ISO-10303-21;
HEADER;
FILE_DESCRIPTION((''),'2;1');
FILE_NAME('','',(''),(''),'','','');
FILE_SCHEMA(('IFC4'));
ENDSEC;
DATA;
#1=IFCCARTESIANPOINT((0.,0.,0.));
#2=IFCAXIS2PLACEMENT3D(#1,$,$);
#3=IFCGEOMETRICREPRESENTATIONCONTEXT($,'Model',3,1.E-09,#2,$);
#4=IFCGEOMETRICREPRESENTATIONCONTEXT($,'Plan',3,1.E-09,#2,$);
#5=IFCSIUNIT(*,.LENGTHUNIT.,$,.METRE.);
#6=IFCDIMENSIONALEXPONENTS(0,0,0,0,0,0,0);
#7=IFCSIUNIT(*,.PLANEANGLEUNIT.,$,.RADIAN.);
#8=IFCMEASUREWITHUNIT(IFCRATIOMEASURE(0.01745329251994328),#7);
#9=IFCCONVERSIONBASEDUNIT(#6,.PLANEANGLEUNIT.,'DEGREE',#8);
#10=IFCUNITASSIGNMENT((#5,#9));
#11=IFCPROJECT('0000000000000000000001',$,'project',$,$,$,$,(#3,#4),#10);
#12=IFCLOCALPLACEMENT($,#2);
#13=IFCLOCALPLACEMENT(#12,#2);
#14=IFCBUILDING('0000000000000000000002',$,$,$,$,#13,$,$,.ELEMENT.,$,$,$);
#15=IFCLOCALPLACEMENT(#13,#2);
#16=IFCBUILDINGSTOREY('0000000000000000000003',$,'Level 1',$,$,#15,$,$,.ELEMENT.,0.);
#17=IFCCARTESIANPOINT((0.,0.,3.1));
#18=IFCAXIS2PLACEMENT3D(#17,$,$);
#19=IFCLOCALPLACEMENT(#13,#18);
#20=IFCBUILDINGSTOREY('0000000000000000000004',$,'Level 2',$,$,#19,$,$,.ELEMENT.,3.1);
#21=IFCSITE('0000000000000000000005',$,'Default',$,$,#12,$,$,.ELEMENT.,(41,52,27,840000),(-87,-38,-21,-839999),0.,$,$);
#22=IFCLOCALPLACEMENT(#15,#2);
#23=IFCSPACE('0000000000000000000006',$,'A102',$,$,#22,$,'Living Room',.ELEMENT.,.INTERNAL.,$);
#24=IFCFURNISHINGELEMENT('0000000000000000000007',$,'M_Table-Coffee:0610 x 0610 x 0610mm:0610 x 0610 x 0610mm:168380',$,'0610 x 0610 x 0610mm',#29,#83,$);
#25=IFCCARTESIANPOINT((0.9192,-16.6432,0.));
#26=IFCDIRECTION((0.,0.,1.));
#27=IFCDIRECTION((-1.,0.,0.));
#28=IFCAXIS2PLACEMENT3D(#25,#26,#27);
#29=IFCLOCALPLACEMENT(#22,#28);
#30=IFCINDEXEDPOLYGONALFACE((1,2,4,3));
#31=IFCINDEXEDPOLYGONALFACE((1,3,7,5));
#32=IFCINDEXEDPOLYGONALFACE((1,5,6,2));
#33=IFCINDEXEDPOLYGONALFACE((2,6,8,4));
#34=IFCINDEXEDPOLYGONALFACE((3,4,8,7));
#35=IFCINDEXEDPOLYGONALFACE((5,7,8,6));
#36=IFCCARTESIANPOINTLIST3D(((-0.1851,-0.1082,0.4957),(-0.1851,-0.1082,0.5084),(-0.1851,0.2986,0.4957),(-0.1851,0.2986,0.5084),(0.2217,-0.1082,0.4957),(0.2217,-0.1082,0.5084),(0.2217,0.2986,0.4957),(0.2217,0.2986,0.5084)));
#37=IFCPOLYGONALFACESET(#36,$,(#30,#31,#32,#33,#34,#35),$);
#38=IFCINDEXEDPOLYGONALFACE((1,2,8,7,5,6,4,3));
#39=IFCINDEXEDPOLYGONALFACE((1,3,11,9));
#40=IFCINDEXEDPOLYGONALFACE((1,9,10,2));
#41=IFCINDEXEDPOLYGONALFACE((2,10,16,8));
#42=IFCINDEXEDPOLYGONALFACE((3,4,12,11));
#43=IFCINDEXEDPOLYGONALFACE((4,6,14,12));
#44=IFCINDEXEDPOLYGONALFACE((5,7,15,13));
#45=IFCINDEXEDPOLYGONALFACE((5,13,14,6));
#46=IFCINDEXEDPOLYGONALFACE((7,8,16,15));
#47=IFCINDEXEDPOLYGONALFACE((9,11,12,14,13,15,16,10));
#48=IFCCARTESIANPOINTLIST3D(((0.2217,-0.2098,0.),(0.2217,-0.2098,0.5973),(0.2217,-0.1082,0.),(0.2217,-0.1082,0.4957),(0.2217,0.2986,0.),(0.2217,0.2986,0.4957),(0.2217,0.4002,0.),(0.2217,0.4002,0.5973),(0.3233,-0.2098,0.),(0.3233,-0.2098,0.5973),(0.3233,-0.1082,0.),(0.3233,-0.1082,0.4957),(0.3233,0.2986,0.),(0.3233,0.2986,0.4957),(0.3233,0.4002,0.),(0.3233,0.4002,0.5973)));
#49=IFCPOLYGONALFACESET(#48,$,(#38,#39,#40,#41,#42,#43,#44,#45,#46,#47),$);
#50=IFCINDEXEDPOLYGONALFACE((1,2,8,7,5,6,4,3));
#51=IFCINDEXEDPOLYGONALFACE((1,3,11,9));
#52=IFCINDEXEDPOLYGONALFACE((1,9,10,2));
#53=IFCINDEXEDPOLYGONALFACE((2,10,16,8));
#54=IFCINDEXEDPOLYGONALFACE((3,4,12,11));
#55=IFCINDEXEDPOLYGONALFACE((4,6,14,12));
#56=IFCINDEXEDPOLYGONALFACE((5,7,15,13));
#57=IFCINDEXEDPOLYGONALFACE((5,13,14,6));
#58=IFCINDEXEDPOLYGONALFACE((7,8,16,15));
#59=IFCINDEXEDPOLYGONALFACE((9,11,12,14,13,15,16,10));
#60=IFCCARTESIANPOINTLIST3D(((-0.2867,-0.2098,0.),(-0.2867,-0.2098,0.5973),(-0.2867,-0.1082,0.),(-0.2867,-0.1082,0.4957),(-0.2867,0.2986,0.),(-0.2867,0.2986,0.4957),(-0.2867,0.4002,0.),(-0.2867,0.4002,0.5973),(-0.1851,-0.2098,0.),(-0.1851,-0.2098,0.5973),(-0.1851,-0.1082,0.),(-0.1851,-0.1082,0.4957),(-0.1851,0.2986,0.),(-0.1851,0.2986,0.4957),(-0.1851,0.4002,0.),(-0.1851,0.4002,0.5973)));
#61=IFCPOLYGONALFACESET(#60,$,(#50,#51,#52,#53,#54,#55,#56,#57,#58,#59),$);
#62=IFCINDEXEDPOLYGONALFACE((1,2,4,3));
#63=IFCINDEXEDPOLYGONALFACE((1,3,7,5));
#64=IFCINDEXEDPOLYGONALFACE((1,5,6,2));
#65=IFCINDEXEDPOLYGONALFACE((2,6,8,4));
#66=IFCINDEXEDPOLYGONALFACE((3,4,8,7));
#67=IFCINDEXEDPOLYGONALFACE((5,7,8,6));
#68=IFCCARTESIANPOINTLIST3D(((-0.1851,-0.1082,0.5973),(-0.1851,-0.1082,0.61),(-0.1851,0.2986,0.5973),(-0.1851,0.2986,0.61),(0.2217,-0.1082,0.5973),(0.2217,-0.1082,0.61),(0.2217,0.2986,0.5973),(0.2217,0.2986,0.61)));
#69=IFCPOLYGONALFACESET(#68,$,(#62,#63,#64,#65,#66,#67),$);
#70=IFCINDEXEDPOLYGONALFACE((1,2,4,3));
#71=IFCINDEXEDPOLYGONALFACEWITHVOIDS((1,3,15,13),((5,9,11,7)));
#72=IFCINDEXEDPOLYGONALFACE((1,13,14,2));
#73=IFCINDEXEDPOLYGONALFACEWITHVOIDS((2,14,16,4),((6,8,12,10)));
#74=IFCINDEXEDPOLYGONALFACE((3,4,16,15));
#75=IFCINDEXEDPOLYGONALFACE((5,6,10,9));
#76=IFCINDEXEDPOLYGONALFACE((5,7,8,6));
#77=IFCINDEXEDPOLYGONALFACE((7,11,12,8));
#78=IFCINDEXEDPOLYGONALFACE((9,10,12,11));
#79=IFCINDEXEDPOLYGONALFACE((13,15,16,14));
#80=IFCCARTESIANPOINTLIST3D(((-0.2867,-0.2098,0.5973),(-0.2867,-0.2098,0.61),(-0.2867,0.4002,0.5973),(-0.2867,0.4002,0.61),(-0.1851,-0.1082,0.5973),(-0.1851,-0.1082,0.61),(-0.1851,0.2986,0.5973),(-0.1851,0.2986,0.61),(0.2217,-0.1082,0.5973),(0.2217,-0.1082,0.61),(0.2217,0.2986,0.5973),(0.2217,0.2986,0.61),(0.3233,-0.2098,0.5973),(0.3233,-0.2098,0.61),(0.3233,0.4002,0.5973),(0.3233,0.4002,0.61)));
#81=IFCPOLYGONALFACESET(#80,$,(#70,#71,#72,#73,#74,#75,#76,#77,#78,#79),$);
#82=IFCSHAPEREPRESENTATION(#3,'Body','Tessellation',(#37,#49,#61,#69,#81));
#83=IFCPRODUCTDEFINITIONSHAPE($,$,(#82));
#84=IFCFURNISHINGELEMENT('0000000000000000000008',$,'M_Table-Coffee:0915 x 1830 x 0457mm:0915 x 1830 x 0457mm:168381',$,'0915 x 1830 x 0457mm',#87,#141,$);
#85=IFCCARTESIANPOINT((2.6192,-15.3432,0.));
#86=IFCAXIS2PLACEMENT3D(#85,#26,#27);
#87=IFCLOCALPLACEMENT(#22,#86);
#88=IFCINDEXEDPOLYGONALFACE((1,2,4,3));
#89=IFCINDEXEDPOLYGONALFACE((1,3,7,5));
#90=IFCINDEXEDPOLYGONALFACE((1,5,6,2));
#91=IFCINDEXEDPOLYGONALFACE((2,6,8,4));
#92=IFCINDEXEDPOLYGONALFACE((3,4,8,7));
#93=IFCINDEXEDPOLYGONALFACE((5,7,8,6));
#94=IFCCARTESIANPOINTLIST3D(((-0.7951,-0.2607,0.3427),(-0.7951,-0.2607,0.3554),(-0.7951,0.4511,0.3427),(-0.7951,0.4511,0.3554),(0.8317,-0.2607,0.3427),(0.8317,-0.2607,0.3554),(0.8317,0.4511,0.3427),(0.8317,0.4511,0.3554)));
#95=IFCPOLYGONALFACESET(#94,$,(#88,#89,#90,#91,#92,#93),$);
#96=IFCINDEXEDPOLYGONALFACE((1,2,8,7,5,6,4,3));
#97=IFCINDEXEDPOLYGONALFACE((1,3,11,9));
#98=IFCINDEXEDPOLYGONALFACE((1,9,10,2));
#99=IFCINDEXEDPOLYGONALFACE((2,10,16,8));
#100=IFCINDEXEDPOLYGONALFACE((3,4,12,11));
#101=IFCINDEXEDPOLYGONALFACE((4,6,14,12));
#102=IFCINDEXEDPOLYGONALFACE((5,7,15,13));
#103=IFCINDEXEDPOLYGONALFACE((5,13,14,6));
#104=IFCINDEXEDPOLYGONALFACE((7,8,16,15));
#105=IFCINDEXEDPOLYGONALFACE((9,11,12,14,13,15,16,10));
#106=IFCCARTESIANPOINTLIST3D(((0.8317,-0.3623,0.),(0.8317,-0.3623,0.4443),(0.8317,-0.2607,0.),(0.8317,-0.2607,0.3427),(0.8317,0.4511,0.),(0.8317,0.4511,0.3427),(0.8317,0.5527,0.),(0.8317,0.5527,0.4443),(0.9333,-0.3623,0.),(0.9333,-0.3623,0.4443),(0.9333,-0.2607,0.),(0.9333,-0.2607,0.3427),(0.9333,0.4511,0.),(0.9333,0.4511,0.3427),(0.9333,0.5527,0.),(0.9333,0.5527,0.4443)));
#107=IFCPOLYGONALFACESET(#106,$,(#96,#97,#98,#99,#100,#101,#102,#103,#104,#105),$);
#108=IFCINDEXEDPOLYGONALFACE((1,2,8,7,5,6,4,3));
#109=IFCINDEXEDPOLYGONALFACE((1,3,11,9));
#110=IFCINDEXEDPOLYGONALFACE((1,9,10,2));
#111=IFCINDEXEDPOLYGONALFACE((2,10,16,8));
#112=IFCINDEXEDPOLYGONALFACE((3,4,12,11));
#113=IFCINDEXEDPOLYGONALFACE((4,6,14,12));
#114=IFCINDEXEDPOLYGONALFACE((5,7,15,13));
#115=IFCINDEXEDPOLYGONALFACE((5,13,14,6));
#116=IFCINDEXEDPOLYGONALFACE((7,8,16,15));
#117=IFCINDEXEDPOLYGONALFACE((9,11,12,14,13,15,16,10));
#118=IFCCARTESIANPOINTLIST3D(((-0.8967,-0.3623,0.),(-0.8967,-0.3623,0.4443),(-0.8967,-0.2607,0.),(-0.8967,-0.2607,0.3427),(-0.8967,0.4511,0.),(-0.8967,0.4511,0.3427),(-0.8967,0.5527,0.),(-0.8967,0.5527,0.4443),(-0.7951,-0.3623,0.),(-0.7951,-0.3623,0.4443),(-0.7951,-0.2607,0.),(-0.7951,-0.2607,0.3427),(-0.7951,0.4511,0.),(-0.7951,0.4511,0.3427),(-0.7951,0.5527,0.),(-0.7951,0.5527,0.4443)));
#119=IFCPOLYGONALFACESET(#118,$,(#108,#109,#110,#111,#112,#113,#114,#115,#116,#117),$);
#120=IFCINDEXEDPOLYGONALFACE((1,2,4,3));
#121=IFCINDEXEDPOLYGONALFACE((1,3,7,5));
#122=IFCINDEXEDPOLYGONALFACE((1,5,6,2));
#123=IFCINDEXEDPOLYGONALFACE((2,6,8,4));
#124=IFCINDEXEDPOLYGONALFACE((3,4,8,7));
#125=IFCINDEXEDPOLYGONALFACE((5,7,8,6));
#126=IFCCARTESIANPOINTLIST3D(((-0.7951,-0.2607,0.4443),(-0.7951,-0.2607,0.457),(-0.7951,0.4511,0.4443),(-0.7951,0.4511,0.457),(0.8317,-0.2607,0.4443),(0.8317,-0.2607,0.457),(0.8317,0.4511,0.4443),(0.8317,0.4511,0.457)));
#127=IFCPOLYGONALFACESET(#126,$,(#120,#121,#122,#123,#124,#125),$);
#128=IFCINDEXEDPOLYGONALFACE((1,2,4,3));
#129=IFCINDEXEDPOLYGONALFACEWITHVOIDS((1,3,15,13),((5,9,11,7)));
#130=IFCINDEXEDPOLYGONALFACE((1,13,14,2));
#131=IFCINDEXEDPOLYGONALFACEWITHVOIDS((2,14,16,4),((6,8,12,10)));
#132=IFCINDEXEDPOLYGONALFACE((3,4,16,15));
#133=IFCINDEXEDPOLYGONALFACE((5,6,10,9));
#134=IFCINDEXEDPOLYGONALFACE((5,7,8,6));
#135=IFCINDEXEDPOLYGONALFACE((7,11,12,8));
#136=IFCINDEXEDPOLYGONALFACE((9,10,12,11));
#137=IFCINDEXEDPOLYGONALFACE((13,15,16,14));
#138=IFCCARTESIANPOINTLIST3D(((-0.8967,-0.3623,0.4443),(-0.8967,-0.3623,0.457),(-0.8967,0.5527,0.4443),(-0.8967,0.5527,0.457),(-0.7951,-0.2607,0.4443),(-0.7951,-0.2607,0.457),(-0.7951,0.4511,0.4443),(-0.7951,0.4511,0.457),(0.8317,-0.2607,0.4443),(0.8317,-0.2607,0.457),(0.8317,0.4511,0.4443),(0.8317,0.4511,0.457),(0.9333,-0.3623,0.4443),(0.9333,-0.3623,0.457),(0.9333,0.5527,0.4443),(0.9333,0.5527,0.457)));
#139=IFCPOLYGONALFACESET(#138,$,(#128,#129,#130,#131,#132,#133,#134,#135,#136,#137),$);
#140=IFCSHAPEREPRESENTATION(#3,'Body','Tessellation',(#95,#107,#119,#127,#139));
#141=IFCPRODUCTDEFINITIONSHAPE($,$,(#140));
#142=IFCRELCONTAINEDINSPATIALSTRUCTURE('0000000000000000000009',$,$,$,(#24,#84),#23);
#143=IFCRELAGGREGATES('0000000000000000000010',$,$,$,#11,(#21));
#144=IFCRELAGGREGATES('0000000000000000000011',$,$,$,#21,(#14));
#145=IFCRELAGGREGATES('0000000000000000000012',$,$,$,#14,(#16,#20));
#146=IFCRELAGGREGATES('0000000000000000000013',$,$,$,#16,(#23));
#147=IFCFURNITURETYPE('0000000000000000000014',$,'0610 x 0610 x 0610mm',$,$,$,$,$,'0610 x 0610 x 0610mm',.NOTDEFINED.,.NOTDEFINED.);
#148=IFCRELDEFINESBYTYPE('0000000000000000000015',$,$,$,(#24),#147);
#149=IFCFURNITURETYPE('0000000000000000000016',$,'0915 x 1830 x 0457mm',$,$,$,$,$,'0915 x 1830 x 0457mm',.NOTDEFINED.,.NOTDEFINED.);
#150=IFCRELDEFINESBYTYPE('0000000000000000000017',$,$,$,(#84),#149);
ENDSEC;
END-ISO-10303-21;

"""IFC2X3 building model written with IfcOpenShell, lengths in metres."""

from ifc_helpers import new_model, entity, si_unit, converted_unit, frame, origin, origin_2d_with_axis, place, context, project, spatial, polyline, rectangle, outline, extrude, source, transform, mapped, type_object, type_shapes, element, save


model = new_model("IFC2X3")

# Units and contexts
model_context = context("Model", 3, precision=1e-09, world=origin())
plan_context = context("Plan", 3, precision=1e-09, world=origin())
ifc_project = project(units=[si_unit("LENGTHUNIT", "METRE"), converted_unit("PLANEANGLEUNIT", "DEGREE", entity("IfcRatioMeasure", 0.01745329251994328), si_unit("PLANEANGLEUNIT", "RADIAN"), dimensions=[0, 0, 0, 0, 0, 0, 0])], contexts=[model_context, plan_context])

# Site, building, storey
site_placement = place(None, origin())
site = spatial("IfcSite", under=ifc_project, at=site_placement, Name="Default", CompositionType="ELEMENT", RefLatitude=(41, 52, 27, 840000), RefLongitude=(-87, -38, -21, -839999), RefElevation=0.0)
building_placement = place(site_placement, origin())
building = spatial("IfcBuilding", under=site, at=building_placement, CompositionType="ELEMENT")
storey_1_placement = place(building_placement, origin())
storey_1 = spatial("IfcBuildingStorey", under=building, at=storey_1_placement, Name="Level 1", CompositionType="ELEMENT", Elevation=0.0)

# Shared definitions
storey_2_placement = place(building_placement, frame((0.0, 0.0, 3.1)))
storey_2 = spatial("IfcBuildingStorey", under=building, at=storey_2_placement, Name="Level 2", CompositionType="ELEMENT", Elevation=3.1)

# Shared definitions
space_1_placement = place(storey_1_placement, origin())
space_1 = spatial("IfcSpace", under=storey_1, at=space_1_placement, Name="A102", LongName="Living Room", CompositionType="ELEMENT", InteriorOrExteriorSpace="INTERNAL")

# Furnishing elements
furniture_type_1 = type_object("IfcFurnitureType", Name="0610 x 0610 x 0610mm", ElementType="0610 x 0610 x 0610mm", AssemblyPlace="NOTDEFINED")
shared_shape_1 = source(origin(), model_context, "Body", "SweptSolid", [
    extrude(rectangle(XDim=0.4068, YDim=0.4068, at=origin_2d_with_axis()), frame((0.0183, 0.0952, 0.4957), z_axis=(0.0, 0.0, 1.0), x_axis=(-1.0, 0.0, 0.0)), (0.0, 0.0, 1.0), 0.0127),
    extrude(outline(polyline([(-0.2732, -0.305), (0.324, -0.305), (0.324, 0.305), (-0.2732, 0.305), (-0.2732, 0.2034), (0.2225, 0.2034), (0.2225, -0.2034), (-0.2732, -0.2034), (-0.2732, -0.305)])), frame((0.2217, 0.0952, 0.2732), z_axis=(1.0, 0.0, 0.0), x_axis=(0.0, 0.0, 1.0)), (0.0, 0.0, 1.0), 0.1016),
    extrude(outline(polyline([(-0.305, -0.3241), (0.305, -0.3241), (0.305, 0.2733), (0.2034, 0.2733), (0.2034, -0.2224), (-0.2034, -0.2224), (-0.2034, 0.2733), (-0.305, 0.2733), (-0.305, -0.3241)])), frame((-0.2867, 0.0952, 0.2733), z_axis=(1.0, 0.0, 0.0), x_axis=(0.0, -1.0, 0.0)), (0.0, 0.0, 1.0), 0.1016),
    extrude(rectangle(XDim=0.4068, YDim=0.4068, at=origin_2d_with_axis()), frame((0.0183, 0.0952, 0.5973), z_axis=(0.0, 0.0, 1.0), x_axis=(-1.0, 0.0, 0.0)), (0.0, 0.0, 1.0), 0.0127),
    extrude(outline(polyline([(-0.305, -0.305), (0.305, -0.305), (0.305, 0.305), (-0.305, 0.305), (-0.305, -0.305)]), holes=[polyline([(-0.2034, -0.2034), (-0.2034, 0.2034), (0.2034, 0.2034), (0.2034, -0.2034), (-0.2034, -0.2034)])]), frame((0.0183, 0.0952, 0.5973), z_axis=(0.0, 0.0, 1.0), x_axis=(-1.0, 0.0, 0.0)), (0.0, 0.0, 1.0), 0.0127),
])
type_shapes(furniture_type_1, [shared_shape_1])
for number, where, z_axis, x_axis, name in (
    (1, (0.9192, -16.6432, 0.0), (0.0, 0.0, 1.0), (-1.0, 0.0, 0.0), "M_Table-Coffee:0610 x 0610 x 0610mm:0610 x 0610 x 0610mm:168380"),
):
    element("IfcFurnishingElement", number, at=place(space_1_placement, frame(where, z_axis=z_axis, x_axis=x_axis)), inside=space_1, type_object=furniture_type_1, Name=name, ObjectType="0610 x 0610 x 0610mm", context=model_context, shape_type="MappedRepresentation", body=[
        mapped(shared_shape_1, transform((0.0, 0.0, 0.0), scale=1.0)),
    ])
furniture_type_2 = type_object("IfcFurnitureType", Name="0915 x 1830 x 0457mm", ElementType="0915 x 1830 x 0457mm", AssemblyPlace="NOTDEFINED")
shared_shape_2 = source(origin(), model_context, "Body", "SweptSolid", [
    extrude(rectangle(XDim=1.6268, YDim=0.7118, at=origin_2d_with_axis()), frame((0.0183, 0.0952, 0.3427), z_axis=(0.0, 0.0, 1.0), x_axis=(-1.0, 0.0, 0.0)), (0.0, 0.0, 1.0), 0.0127),
    extrude(outline(polyline([(-0.1967, -0.4575), (0.2475, -0.4575), (0.2475, 0.4575), (-0.1967, 0.4575), (-0.1967, 0.3559), (0.146, 0.3559), (0.146, -0.3559), (-0.1967, -0.3559), (-0.1967, -0.4575)])), frame((0.8317, 0.0952, 0.1967), z_axis=(1.0, 0.0, 0.0), x_axis=(0.0, 0.0, 1.0)), (0.0, 0.0, 1.0), 0.1016),
    extrude(outline(polyline([(-0.4575, -0.2476), (0.4575, -0.2476), (0.4575, 0.1968), (0.3559, 0.1968), (0.3559, -0.1459), (-0.3559, -0.1459), (-0.3559, 0.1968), (-0.4575, 0.1968), (-0.4575, -0.2476)])), frame((-0.8967, 0.0952, 0.1968), z_axis=(1.0, 0.0, 0.0), x_axis=(0.0, -1.0, 0.0)), (0.0, 0.0, 1.0), 0.1016),
    extrude(rectangle(XDim=1.6268, YDim=0.7118, at=origin_2d_with_axis()), frame((0.0183, 0.0952, 0.4443), z_axis=(0.0, 0.0, 1.0), x_axis=(-1.0, 0.0, 0.0)), (0.0, 0.0, 1.0), 0.0127),
    extrude(outline(polyline([(-0.915, -0.4575), (0.915, -0.4575), (0.915, 0.4575), (-0.915, 0.4575), (-0.915, -0.4575)]), holes=[polyline([(-0.8134, -0.3559), (-0.8134, 0.3559), (0.8134, 0.3559), (0.8134, -0.3559), (-0.8134, -0.3559)])]), frame((0.0183, 0.0952, 0.4443), z_axis=(0.0, 0.0, 1.0), x_axis=(-1.0, 0.0, 0.0)), (0.0, 0.0, 1.0), 0.0127),
])
type_shapes(furniture_type_2, [shared_shape_2])
furnishing_1_placement = place(space_1_placement, frame((2.6192, -15.3432, 0.0), z_axis=(0.0, 0.0, 1.0), x_axis=(-1.0, 0.0, 0.0)))
element("IfcFurnishingElement", 2, at=furnishing_1_placement, inside=space_1, type_object=furniture_type_2, Name="M_Table-Coffee:0915 x 1830 x 0457mm:0915 x 1830 x 0457mm:168381", ObjectType="0915 x 1830 x 0457mm", context=model_context, shape_type="MappedRepresentation", body=[
    mapped(shared_shape_2, transform((0.0, 0.0, 0.0), scale=1.0)),
])

save(model, "model.ifc")
